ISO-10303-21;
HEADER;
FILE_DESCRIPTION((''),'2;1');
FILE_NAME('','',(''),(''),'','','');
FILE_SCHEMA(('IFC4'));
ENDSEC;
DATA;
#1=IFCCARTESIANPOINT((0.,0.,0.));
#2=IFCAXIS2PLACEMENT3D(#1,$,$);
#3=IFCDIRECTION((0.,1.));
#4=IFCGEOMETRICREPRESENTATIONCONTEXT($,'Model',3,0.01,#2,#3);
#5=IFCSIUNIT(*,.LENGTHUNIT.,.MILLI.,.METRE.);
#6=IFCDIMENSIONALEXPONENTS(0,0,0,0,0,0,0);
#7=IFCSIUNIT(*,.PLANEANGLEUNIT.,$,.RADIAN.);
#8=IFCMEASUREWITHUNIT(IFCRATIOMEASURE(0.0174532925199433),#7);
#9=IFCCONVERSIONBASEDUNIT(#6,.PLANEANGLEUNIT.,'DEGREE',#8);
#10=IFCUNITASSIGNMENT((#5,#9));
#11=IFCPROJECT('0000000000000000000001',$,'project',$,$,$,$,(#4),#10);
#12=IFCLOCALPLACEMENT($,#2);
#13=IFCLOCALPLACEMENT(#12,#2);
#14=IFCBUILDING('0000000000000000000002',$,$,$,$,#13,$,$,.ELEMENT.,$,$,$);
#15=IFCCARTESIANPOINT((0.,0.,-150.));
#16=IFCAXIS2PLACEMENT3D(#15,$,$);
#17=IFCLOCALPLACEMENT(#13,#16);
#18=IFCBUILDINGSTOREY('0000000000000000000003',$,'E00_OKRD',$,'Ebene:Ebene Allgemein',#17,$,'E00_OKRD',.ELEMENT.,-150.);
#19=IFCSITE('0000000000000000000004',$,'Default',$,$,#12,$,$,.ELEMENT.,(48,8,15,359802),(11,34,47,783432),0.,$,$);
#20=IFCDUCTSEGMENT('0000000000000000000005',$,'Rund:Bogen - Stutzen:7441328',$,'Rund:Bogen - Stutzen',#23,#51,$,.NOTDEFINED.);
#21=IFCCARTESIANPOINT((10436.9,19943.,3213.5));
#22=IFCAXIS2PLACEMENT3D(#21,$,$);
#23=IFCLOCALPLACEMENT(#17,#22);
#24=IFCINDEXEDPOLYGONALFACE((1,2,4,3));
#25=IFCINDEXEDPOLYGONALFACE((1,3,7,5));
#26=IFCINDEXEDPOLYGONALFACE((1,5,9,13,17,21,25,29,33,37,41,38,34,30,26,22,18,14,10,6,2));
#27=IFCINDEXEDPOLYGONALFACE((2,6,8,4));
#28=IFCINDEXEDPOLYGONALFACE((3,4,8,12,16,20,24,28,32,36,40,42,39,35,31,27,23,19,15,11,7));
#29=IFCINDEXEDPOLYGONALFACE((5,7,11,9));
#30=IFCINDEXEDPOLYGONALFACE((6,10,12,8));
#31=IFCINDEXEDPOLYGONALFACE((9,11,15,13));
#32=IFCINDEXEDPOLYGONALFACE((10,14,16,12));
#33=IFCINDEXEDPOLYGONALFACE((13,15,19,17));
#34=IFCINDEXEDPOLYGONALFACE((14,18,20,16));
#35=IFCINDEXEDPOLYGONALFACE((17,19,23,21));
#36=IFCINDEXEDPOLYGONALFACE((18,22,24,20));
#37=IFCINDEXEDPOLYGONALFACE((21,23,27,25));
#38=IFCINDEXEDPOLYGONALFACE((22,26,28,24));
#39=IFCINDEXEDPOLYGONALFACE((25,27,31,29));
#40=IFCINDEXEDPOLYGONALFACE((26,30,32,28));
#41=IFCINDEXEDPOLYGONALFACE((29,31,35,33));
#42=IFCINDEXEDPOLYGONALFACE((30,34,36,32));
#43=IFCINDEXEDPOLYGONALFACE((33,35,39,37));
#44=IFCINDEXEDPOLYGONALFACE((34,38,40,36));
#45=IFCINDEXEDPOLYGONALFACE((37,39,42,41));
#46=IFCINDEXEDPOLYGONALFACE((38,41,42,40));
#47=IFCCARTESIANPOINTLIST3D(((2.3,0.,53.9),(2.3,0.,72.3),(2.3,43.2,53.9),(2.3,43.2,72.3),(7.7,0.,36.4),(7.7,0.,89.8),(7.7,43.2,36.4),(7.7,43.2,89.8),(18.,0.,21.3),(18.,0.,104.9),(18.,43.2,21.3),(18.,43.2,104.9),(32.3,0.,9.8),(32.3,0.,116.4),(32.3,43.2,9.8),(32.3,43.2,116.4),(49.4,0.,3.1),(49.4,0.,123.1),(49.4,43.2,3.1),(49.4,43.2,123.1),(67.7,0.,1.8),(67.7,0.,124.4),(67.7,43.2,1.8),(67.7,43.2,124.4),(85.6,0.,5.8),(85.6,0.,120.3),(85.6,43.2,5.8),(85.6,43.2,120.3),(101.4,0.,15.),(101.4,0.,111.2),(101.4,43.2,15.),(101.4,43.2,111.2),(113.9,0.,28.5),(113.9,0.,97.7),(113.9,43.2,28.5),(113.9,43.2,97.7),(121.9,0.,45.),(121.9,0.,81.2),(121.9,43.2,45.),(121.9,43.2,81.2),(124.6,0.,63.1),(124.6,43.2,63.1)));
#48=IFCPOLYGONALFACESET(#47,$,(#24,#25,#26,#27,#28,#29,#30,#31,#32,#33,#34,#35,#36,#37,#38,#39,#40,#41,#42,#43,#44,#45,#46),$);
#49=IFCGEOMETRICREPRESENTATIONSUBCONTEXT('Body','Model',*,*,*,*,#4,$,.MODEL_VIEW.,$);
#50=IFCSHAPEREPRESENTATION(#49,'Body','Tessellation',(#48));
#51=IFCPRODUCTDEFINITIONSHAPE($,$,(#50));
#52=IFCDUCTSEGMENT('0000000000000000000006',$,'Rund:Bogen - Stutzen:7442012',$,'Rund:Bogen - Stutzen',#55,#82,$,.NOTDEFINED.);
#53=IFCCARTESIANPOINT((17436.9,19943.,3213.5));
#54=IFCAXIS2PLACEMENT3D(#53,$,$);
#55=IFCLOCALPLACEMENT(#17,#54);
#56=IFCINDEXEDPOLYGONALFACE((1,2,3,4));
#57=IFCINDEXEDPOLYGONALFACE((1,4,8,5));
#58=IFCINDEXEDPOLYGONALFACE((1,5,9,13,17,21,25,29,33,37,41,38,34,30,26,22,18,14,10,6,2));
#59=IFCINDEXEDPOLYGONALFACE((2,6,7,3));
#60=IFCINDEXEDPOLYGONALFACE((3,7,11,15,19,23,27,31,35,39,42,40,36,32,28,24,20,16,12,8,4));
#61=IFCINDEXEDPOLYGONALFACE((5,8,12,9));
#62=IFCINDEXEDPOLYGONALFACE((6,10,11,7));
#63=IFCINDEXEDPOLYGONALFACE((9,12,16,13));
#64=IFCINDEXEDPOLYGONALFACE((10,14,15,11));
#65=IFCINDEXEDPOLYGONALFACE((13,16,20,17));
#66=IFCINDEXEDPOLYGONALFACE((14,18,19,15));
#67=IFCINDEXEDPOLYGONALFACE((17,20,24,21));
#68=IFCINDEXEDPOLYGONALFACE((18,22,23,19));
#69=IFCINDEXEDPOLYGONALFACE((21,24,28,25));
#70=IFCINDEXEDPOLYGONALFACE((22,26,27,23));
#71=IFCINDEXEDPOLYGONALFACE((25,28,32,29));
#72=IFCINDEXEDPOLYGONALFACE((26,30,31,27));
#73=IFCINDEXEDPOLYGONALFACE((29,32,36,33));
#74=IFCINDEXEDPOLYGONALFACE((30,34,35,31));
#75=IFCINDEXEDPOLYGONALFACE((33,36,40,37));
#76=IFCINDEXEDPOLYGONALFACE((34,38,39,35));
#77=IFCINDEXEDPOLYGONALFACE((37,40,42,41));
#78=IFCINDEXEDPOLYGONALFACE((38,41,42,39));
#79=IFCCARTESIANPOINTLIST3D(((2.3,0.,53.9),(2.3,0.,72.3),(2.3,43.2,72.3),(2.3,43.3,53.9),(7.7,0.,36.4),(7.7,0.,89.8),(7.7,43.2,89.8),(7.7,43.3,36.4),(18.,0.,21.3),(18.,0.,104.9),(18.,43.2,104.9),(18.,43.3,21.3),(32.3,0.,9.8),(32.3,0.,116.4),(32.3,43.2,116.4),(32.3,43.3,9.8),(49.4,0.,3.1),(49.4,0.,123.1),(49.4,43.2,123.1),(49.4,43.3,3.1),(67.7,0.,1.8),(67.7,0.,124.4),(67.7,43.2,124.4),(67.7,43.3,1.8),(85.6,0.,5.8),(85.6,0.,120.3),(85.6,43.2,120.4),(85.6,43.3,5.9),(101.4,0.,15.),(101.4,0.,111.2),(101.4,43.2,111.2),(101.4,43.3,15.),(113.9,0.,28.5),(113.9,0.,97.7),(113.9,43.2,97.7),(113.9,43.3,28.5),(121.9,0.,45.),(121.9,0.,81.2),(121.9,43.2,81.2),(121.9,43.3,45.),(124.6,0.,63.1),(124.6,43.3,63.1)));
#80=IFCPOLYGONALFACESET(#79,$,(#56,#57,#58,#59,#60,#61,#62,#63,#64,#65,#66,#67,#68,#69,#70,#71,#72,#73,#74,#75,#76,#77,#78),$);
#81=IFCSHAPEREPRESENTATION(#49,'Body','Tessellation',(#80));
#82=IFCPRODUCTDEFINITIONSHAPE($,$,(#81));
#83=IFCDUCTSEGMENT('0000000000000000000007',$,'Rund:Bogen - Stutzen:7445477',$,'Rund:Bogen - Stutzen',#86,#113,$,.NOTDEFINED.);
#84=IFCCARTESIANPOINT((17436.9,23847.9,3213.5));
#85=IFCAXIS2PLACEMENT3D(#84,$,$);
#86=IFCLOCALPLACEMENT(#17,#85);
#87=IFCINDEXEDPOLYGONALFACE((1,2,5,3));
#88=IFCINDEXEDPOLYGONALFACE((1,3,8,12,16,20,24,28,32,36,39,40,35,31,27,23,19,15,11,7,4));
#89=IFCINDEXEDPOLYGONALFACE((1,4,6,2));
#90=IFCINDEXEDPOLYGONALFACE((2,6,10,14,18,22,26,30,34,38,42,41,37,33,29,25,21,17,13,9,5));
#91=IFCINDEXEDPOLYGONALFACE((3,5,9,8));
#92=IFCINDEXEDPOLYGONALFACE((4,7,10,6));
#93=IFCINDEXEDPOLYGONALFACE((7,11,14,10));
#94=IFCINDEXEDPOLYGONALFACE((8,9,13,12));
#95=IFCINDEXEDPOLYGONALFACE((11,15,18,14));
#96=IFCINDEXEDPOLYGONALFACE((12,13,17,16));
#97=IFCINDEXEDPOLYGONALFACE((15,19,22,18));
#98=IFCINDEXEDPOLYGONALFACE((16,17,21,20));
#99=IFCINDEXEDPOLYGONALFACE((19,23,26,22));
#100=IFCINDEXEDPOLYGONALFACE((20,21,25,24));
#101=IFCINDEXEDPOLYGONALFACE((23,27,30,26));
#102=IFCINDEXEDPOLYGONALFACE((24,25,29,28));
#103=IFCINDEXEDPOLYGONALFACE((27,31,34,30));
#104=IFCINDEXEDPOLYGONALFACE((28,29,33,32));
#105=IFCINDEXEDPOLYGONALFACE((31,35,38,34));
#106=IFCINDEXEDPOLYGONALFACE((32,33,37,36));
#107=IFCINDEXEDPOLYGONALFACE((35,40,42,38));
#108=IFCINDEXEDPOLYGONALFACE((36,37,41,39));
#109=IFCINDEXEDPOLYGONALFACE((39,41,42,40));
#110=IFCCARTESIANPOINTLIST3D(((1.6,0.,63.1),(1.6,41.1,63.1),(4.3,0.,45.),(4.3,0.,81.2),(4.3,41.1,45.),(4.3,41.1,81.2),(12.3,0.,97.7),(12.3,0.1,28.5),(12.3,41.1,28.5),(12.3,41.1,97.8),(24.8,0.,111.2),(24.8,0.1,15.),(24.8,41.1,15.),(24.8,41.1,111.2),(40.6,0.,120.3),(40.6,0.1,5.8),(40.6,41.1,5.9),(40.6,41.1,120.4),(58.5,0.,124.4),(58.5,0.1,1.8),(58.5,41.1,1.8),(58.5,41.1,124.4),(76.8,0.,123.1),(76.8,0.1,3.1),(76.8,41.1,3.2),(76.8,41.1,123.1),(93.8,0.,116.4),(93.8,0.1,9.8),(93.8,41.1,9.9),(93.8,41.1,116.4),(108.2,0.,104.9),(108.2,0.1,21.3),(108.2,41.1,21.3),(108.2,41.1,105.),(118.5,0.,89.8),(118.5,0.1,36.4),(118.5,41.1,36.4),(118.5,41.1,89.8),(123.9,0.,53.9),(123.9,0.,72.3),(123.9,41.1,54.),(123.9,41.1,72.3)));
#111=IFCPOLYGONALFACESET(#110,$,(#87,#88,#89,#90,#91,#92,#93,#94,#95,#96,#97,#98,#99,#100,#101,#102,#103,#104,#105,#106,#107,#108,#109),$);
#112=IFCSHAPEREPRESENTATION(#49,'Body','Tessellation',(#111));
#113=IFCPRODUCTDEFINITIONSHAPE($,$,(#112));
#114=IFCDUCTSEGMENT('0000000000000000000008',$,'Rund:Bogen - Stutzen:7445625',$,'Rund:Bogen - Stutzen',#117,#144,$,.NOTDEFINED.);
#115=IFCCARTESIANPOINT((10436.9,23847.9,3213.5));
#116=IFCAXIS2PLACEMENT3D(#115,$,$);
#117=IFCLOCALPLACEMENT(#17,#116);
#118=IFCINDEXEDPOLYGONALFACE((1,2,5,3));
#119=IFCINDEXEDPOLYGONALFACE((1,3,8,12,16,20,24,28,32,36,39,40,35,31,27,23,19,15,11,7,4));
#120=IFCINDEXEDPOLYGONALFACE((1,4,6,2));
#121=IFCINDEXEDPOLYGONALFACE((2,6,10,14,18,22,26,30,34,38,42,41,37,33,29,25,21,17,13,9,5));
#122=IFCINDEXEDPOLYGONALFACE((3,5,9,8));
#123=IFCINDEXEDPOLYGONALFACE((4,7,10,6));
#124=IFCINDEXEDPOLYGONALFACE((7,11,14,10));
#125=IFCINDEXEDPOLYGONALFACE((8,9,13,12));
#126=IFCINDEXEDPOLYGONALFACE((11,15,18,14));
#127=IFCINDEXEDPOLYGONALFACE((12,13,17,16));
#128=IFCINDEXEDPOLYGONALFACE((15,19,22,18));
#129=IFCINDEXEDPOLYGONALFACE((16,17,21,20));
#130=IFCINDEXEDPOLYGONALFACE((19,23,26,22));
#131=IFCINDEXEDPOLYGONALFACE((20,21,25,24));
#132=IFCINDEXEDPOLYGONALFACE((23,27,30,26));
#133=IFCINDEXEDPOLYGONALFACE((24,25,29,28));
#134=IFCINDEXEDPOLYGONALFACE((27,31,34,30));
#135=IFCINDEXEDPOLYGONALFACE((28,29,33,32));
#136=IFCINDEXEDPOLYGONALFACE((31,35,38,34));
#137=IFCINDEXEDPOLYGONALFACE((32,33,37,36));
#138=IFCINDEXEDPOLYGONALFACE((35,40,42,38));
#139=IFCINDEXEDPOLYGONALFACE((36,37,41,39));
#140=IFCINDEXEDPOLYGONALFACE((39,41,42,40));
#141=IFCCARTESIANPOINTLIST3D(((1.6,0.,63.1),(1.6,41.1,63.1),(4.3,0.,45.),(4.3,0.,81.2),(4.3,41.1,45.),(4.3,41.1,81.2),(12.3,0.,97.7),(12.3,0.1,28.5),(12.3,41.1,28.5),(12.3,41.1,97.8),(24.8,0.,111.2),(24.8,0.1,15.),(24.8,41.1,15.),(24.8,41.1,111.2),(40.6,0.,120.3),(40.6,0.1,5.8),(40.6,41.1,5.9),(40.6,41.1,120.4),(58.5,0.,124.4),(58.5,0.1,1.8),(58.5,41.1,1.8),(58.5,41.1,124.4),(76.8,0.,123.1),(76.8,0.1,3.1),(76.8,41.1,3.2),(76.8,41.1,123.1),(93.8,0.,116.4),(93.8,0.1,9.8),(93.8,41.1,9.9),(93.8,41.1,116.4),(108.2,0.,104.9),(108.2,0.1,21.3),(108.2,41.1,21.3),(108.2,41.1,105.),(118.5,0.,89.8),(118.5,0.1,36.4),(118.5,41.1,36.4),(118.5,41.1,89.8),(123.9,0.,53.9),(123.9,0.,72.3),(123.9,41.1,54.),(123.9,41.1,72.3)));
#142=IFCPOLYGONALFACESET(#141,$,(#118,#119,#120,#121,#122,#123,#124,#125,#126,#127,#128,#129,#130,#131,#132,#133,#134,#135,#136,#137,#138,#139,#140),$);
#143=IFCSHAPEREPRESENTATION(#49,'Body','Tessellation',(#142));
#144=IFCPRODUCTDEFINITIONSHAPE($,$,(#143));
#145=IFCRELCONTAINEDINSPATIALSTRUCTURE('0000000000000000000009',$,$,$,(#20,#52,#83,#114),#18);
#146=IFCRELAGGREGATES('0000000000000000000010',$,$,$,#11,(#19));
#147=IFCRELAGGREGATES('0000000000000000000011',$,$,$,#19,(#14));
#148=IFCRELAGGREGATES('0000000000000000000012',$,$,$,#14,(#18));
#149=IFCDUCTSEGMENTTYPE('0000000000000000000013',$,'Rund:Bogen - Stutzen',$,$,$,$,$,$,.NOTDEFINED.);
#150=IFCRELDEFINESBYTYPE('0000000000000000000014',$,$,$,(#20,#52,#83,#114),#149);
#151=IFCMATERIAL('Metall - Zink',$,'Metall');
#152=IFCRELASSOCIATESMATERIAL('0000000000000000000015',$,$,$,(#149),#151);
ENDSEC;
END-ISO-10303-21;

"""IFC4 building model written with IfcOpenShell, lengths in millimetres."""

from ifc_helpers import new_model, entity, si_unit, converted_unit, direction, frame, frame_2d, origin, origin_2d_with_axis, place, context, subcontext, project, spatial, circle, extrude, material, type_object, element, save


model = new_model("IFC4")

# Units and contexts
model_context = context("Model", 3, precision=0.01, world=origin(), true_north=direction((0.0, 1.0)))
body_context = subcontext(model_context, "Body", "Model", "MODEL_VIEW")
ifc_project = project(units=[si_unit("LENGTHUNIT", "METRE", prefix="MILLI"), converted_unit("PLANEANGLEUNIT", "DEGREE", entity("IfcRatioMeasure", 0.0174532925199433), si_unit("PLANEANGLEUNIT", "RADIAN"), dimensions=[0, 0, 0, 0, 0, 0, 0])], contexts=[model_context])

# Site, building, storey
site_placement = place(None, origin())
site = spatial("IfcSite", under=ifc_project, at=site_placement, Name="Default", CompositionType="ELEMENT", RefLatitude=(48, 8, 15, 359802), RefLongitude=(11, 34, 47, 783432), RefElevation=0.0)
building_placement = place(site_placement, origin())
building = spatial("IfcBuilding", under=site, at=building_placement, CompositionType="ELEMENT")
storey_placement = place(building_placement, frame((0.0, 0.0, -150.0)))
storey = spatial("IfcBuildingStorey", under=building, at=storey_placement, Name="E00_OKRD", ObjectType="Ebene:Ebene Allgemein", LongName="E00_OKRD", CompositionType="ELEMENT", Elevation=-150.0)

# Shared definitions
ifc_material_1 = material(Name="Metall - Zink", Category="Metall")

# Duct segments
duct_segment_type_1 = type_object("IfcDuctSegmentType", Name="Rund:Bogen - Stutzen", PredefinedType="NOTDEFINED", material=ifc_material_1)
duct_segment_1_placement = place(storey_placement, frame((10436.9, 19943.0, 3213.5)))
element("IfcDuctSegment", 1, at=duct_segment_1_placement, inside=storey, type_object=duct_segment_type_1, Name="Rund:Bogen - Stutzen:7441328", ObjectType="Rund:Bogen - Stutzen", PredefinedType="NOTDEFINED", context=body_context, shape_type="SweptSolid", body=[
    extrude(circle(Radius=61.5, at=origin_2d_with_axis()), frame((63.1, 0.0, 63.1), z_axis=(0.0, 1.0, 0.0), x_axis=(1.0, 0.0, 0.0)), (0.0, 0.0, 1.0), 43.2),
])
duct_segment_2_placement = place(storey_placement, frame((17436.9, 19943.0, 3213.5)))
element("IfcDuctSegment", 2, at=duct_segment_2_placement, inside=storey, type_object=duct_segment_type_1, Name="Rund:Bogen - Stutzen:7442012", ObjectType="Rund:Bogen - Stutzen", PredefinedType="NOTDEFINED", context=body_context, shape_type="SweptSolid", body=[
    extrude(circle(Radius=61.5, at=origin_2d_with_axis()), frame((63.1, 0.0, 63.1), z_axis=(0.0, 1.0, 0.000188), x_axis=(1.0, 0.0, 0.0)), (0.0, 0.0, 1.0), 43.2),
])
duct_segment_3_placement = place(storey_placement, frame((17436.9, 23847.9, 3213.5)))
element("IfcDuctSegment", 3, at=duct_segment_3_placement, inside=storey, type_object=duct_segment_type_1, Name="Rund:Bogen - Stutzen:7445477", ObjectType="Rund:Bogen - Stutzen", PredefinedType="NOTDEFINED", context=body_context, shape_type="SweptSolid", body=[
    extrude(circle(Radius=61.5, at=frame_2d((0.0, 0.0), x_axis=(1.0, 0.0))), frame((63.1, 0.0, 63.1), z_axis=(0.0, 1.0, 0.000627), x_axis=(-1.0, 0.0, 0.0)), (0.0, 0.0, 1.0), 41.1),
])
duct_segment_4_placement = place(storey_placement, frame((10436.9, 23847.9, 3213.5)))
element("IfcDuctSegment", 4, at=duct_segment_4_placement, inside=storey, type_object=duct_segment_type_1, Name="Rund:Bogen - Stutzen:7445625", ObjectType="Rund:Bogen - Stutzen", PredefinedType="NOTDEFINED", context=body_context, shape_type="SweptSolid", body=[
    extrude(circle(Radius=61.5, at=frame_2d((0.0, 0.0), x_axis=(1.0, 0.0))), frame((63.1, 0.0, 63.1), z_axis=(0.0, 1.0, 0.000627), x_axis=(-1.0, 0.0, 0.0)), (0.0, 0.0, 1.0), 41.1),
])

save(model, "model.ifc")
